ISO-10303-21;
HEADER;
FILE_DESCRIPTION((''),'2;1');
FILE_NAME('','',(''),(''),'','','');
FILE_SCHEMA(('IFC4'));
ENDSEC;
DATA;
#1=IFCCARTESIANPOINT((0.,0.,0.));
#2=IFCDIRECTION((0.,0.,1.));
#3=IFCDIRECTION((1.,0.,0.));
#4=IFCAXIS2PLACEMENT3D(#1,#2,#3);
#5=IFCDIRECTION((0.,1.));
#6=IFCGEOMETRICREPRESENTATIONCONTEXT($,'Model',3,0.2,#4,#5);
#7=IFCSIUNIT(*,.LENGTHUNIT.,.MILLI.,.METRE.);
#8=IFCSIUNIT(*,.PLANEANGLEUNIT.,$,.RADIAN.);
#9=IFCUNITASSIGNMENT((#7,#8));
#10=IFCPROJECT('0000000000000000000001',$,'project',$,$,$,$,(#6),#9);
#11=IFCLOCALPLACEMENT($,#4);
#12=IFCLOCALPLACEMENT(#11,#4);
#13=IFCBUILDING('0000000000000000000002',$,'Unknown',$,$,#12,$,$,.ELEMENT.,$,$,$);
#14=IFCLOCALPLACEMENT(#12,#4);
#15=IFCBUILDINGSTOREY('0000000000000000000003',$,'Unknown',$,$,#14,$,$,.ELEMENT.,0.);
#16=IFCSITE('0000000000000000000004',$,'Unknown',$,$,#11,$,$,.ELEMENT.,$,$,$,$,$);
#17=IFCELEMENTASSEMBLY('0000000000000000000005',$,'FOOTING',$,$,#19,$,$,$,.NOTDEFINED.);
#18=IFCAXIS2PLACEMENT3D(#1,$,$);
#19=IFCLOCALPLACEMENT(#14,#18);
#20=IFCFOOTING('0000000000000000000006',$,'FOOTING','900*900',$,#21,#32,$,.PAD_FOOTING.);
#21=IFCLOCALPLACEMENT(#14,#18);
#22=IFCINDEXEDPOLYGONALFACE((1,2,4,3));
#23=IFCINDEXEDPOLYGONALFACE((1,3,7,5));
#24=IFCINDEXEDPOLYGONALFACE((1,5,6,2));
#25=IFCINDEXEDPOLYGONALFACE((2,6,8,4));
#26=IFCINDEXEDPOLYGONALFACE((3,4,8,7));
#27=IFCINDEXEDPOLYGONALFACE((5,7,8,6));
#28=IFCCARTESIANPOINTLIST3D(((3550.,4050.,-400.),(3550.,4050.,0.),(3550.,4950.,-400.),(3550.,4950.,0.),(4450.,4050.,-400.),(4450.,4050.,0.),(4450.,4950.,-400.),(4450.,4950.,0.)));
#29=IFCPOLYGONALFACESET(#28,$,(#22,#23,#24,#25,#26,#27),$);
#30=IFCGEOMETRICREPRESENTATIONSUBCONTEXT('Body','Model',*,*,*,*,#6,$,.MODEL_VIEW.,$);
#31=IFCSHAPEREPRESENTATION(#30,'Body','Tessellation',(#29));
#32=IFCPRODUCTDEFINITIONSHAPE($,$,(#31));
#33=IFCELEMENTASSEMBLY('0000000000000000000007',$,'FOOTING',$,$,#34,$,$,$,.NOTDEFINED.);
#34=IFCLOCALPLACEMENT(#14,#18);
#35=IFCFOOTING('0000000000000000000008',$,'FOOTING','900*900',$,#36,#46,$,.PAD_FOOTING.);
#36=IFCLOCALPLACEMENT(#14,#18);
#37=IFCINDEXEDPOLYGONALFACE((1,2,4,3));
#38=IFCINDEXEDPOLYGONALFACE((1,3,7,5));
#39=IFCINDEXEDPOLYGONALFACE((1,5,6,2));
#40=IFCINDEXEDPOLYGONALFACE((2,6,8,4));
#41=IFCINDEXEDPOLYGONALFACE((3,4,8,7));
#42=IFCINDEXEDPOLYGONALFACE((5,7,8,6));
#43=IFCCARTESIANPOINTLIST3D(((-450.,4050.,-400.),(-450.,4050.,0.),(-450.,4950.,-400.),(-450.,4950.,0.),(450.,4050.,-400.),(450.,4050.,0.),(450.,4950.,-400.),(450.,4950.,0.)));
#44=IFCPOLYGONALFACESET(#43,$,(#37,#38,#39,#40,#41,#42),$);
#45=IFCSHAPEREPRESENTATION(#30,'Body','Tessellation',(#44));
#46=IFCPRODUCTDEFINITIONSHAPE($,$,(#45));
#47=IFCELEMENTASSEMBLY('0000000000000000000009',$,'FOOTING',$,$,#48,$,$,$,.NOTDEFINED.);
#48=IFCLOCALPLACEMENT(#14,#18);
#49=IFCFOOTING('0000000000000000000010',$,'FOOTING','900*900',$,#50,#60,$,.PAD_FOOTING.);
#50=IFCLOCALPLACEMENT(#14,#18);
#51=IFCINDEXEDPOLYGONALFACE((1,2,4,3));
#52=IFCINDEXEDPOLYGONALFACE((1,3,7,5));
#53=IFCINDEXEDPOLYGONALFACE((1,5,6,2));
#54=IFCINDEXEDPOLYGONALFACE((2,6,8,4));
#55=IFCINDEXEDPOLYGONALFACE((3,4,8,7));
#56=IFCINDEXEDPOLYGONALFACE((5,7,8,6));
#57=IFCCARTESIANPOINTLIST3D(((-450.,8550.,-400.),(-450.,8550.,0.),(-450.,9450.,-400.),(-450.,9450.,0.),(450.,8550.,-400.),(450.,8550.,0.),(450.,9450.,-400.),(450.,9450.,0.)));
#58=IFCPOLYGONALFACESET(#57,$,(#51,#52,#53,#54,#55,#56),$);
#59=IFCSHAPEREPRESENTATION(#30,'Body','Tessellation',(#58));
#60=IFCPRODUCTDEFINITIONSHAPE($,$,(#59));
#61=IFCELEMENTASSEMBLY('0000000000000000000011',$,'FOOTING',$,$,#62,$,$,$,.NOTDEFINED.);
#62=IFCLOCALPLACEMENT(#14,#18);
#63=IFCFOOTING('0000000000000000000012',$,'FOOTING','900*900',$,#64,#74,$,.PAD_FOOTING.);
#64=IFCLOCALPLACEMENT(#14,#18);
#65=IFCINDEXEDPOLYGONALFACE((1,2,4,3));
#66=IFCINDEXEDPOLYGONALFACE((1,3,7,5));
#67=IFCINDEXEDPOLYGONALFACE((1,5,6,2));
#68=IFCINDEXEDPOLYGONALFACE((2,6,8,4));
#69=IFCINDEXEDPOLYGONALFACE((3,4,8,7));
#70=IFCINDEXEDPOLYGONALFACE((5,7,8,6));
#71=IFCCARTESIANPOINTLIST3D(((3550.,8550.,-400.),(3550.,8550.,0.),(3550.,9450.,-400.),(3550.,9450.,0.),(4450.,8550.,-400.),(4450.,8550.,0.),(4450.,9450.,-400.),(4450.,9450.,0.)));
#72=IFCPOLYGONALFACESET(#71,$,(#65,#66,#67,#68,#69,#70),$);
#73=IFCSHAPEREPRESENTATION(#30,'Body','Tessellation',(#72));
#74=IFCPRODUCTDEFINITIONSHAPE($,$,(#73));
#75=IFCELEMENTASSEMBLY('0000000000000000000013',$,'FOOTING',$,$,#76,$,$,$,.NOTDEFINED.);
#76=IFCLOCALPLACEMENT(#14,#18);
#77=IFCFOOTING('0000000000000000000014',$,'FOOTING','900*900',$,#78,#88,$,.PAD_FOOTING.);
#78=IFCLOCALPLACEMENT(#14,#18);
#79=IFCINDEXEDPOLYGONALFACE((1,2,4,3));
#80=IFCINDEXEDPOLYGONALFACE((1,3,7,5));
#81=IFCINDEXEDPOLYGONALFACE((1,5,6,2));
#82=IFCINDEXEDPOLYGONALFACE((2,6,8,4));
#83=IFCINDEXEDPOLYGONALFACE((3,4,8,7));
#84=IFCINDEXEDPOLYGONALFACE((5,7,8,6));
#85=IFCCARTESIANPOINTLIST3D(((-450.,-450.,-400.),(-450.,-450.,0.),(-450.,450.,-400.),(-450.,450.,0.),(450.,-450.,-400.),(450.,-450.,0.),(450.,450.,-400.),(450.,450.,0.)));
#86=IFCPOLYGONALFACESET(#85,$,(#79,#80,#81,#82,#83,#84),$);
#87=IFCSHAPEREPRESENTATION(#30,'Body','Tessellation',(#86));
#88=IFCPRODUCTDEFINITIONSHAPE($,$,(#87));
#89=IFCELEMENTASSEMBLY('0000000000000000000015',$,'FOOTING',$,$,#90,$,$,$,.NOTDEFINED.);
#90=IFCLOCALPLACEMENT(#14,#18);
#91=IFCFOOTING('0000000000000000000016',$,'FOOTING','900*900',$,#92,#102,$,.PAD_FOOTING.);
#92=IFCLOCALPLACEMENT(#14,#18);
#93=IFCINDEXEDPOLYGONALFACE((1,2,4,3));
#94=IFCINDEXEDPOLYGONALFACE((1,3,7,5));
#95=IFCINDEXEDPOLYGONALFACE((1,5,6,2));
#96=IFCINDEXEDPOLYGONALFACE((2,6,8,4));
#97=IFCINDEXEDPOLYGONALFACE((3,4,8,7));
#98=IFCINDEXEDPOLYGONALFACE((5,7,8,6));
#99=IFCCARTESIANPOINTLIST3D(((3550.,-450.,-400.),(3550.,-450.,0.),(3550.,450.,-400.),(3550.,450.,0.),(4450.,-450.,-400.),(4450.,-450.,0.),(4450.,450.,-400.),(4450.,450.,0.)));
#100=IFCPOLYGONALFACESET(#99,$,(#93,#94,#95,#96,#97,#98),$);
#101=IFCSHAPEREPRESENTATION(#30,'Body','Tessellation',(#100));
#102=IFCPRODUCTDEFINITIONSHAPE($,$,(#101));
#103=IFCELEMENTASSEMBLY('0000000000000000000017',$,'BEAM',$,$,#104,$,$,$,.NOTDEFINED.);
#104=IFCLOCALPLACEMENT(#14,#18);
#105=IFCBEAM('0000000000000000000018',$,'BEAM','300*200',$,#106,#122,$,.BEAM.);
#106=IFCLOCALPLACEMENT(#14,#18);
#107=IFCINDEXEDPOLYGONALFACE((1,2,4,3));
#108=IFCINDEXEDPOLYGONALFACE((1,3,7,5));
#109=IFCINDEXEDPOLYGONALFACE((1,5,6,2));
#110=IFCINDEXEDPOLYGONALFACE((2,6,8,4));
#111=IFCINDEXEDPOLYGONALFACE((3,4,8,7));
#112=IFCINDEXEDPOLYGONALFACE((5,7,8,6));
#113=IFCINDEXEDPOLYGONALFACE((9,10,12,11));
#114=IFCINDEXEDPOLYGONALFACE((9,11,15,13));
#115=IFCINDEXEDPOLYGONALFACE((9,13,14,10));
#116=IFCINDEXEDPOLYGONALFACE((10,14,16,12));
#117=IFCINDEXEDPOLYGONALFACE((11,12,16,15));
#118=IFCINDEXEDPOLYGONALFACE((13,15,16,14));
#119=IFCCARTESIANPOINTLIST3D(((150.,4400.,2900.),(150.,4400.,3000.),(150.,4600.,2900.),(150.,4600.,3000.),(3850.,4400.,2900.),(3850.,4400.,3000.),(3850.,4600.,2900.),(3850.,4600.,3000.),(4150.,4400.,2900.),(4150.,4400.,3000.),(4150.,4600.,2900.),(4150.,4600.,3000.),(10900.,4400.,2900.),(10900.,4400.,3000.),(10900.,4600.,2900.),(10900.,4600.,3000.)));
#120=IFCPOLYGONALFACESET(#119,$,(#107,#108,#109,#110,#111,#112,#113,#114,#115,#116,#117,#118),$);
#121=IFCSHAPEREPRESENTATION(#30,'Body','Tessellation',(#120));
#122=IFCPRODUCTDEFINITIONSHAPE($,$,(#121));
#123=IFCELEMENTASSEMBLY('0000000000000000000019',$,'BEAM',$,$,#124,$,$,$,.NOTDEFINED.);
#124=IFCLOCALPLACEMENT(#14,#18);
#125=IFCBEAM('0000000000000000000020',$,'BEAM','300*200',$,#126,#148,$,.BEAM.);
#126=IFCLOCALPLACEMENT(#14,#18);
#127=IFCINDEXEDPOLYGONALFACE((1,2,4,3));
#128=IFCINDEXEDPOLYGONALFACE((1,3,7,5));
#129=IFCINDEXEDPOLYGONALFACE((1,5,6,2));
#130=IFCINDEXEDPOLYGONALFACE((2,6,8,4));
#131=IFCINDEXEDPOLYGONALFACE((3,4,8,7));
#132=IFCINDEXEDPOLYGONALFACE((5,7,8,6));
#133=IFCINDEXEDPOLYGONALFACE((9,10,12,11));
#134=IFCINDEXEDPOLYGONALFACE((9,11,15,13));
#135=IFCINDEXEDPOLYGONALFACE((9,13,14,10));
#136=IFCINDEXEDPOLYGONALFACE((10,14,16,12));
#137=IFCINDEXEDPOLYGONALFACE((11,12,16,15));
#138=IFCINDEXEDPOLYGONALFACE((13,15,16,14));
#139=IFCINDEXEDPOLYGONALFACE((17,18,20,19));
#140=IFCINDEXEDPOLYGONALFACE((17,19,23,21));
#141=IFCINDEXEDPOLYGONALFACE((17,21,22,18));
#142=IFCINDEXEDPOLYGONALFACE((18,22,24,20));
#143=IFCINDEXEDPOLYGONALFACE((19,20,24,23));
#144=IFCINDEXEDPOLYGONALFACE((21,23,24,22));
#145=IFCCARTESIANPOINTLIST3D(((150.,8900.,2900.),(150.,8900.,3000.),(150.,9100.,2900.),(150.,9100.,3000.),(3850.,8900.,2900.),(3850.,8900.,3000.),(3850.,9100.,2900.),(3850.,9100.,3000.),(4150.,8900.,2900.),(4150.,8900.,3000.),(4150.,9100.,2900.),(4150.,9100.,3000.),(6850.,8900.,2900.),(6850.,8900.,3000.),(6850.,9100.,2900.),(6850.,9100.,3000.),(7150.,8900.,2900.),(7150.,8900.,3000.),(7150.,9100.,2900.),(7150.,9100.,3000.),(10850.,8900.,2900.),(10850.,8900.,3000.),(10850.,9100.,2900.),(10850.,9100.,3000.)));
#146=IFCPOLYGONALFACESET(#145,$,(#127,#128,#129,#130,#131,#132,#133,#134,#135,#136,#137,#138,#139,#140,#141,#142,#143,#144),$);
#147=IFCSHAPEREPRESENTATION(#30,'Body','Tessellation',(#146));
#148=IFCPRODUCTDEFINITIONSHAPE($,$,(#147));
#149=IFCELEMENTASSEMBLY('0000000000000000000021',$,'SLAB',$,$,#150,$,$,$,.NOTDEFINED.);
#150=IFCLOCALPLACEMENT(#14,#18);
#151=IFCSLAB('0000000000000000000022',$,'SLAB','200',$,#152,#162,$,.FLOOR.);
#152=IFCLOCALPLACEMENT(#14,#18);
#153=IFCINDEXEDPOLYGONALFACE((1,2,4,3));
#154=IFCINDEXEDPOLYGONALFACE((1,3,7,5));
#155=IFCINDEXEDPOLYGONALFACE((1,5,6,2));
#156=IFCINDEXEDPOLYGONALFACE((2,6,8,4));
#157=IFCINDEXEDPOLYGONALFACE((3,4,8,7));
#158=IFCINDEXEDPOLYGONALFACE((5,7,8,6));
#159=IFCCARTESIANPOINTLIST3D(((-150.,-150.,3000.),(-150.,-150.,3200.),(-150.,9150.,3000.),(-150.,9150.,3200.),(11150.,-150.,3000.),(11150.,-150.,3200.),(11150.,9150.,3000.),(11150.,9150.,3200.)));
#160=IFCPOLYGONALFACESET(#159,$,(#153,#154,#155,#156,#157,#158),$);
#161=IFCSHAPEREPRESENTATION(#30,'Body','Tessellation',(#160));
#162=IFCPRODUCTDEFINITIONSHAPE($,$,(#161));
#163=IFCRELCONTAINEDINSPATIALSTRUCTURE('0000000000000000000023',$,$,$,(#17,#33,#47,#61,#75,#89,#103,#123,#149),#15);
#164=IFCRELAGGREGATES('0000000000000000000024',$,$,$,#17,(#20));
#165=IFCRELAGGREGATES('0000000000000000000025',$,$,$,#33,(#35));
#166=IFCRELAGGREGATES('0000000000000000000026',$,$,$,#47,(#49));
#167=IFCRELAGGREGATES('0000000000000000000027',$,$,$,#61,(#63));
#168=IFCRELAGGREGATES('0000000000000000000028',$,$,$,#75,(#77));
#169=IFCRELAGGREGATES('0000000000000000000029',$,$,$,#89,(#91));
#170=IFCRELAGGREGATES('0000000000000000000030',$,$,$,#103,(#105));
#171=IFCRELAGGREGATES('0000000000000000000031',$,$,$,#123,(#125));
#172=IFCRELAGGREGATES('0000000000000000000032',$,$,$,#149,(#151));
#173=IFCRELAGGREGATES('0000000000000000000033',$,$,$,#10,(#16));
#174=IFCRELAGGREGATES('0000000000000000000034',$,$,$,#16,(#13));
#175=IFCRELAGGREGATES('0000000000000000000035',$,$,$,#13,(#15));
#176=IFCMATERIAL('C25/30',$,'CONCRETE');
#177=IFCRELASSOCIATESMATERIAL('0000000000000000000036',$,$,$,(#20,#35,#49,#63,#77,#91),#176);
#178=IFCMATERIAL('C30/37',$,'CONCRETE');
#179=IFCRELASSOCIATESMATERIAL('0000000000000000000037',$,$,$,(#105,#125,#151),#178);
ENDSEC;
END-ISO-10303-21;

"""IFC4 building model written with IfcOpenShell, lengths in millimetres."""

from ifc_helpers import new_model, si_unit, direction, frame, origin_with_axes, place, context, subcontext, project, spatial, line, indexed_curve, outline, extrude, material, element, aggregate, save


model = new_model("IFC4")

# Units and contexts
model_context = context("Model", 3, precision=0.2, world=origin_with_axes(), true_north=direction((0.0, 1.0)))
body_context = subcontext(model_context, "Body", "Model", "MODEL_VIEW")
ifc_project = project(units=[si_unit("LENGTHUNIT", "METRE", prefix="MILLI"), si_unit("PLANEANGLEUNIT", "RADIAN")], contexts=[model_context])

# Site, building, storey
site_placement = place(None, origin_with_axes())
site = spatial("IfcSite", under=ifc_project, at=site_placement, Name="Unknown", CompositionType="ELEMENT")
building_placement = place(site_placement, origin_with_axes())
building = spatial("IfcBuilding", under=site, at=building_placement, Name="Unknown", CompositionType="ELEMENT")
storey_placement = place(building_placement, origin_with_axes())
storey = spatial("IfcBuildingStorey", under=building, at=storey_placement, Name="Unknown", CompositionType="ELEMENT", Elevation=0.0)

# Element assemblies, footings
assembly_1_placement = place(storey_placement, frame((4000.0, 4500.0, -400.0), z_axis=(-1.0, 0.0, 0.0), x_axis=(0.0, 0.0, 1.0)))
assembly_1 = element("IfcElementAssembly", 1, at=assembly_1_placement, inside=storey, Name="FOOTING", PredefinedType="NOTDEFINED")
ifc_material_1 = material(Name="C25/30", Category="CONCRETE")
footing_1_placement = place(assembly_1_placement, origin_with_axes())
footing_1 = element("IfcFooting", 2, at=footing_1_placement, material=ifc_material_1, Name="FOOTING", Description="900*900", PredefinedType="PAD_FOOTING", context=body_context, shape_type="SolidModel", body=[
    extrude(outline(indexed_curve([(-450.0, -450.0), (450.0, -450.0), (450.0, 450.0), (-450.0, 450.0)], segments=[line(1, 2, 3, 4, 1)])), frame((0.0, 0.0, 0.0), z_axis=(-1.0, 0.0, 0.0), x_axis=(0.0, 0.0, 1.0)), (0.0, 0.0, -1.0), 400.0),
])
aggregate(assembly_1, [footing_1])
assembly_2_placement = place(storey_placement, frame((0.0, 4500.0, -400.0), z_axis=(-1.0, 0.0, 0.0), x_axis=(0.0, 0.0, 1.0)))
assembly_2 = element("IfcElementAssembly", 3, at=assembly_2_placement, inside=storey, Name="FOOTING", PredefinedType="NOTDEFINED")
footing_2_placement = place(assembly_2_placement, origin_with_axes())
footing_2 = element("IfcFooting", 4, at=footing_2_placement, material=ifc_material_1, Name="FOOTING", Description="900*900", PredefinedType="PAD_FOOTING", context=body_context, shape_type="SolidModel", body=[
    extrude(outline(indexed_curve([(-450.0, -450.0), (450.0, -450.0), (450.0, 450.0), (-450.0, 450.0)], segments=[line(1, 2, 3, 4, 1)])), frame((0.0, 0.0, 0.0), z_axis=(-1.0, 0.0, 0.0), x_axis=(0.0, 0.0, 1.0)), (0.0, 0.0, -1.0), 400.0),
])
aggregate(assembly_2, [footing_2])
assembly_3_placement = place(storey_placement, frame((0.0, 9000.0, -400.0), z_axis=(-1.0, 0.0, 0.0), x_axis=(0.0, 0.0, 1.0)))
assembly_3 = element("IfcElementAssembly", 5, at=assembly_3_placement, inside=storey, Name="FOOTING", PredefinedType="NOTDEFINED")
footing_3_placement = place(assembly_3_placement, origin_with_axes())
footing_3 = element("IfcFooting", 6, at=footing_3_placement, material=ifc_material_1, Name="FOOTING", Description="900*900", PredefinedType="PAD_FOOTING", context=body_context, shape_type="SolidModel", body=[
    extrude(outline(indexed_curve([(-450.0, -450.0), (450.0, -450.0), (450.0, 450.0), (-450.0, 450.0)], segments=[line(1, 2, 3, 4, 1)])), frame((0.0, 0.0, 0.0), z_axis=(-1.0, 0.0, 0.0), x_axis=(0.0, 0.0, 1.0)), (0.0, 0.0, -1.0), 400.0),
])
aggregate(assembly_3, [footing_3])
assembly_4_placement = place(storey_placement, frame((4000.0, 9000.0, -400.0), z_axis=(-1.0, 0.0, 0.0), x_axis=(0.0, 0.0, 1.0)))
assembly_4 = element("IfcElementAssembly", 7, at=assembly_4_placement, inside=storey, Name="FOOTING", PredefinedType="NOTDEFINED")
footing_4_placement = place(assembly_4_placement, origin_with_axes())
footing_4 = element("IfcFooting", 8, at=footing_4_placement, material=ifc_material_1, Name="FOOTING", Description="900*900", PredefinedType="PAD_FOOTING", context=body_context, shape_type="SolidModel", body=[
    extrude(outline(indexed_curve([(-450.0, -450.0), (450.0, -450.0), (450.0, 450.0), (-450.0, 450.0)], segments=[line(1, 2, 3, 4, 1)])), frame((0.0, 0.0, 0.0), z_axis=(-1.0, 0.0, 0.0), x_axis=(0.0, 0.0, 1.0)), (0.0, 0.0, -1.0), 400.0),
])
aggregate(assembly_4, [footing_4])
assembly_5_placement = place(storey_placement, frame((0.0, 0.0, -400.0), z_axis=(-1.0, 0.0, 0.0), x_axis=(0.0, 0.0, 1.0)))
assembly_5 = element("IfcElementAssembly", 9, at=assembly_5_placement, inside=storey, Name="FOOTING", PredefinedType="NOTDEFINED")
footing_5_placement = place(assembly_5_placement, origin_with_axes())
footing_5 = element("IfcFooting", 10, at=footing_5_placement, material=ifc_material_1, Name="FOOTING", Description="900*900", PredefinedType="PAD_FOOTING", context=body_context, shape_type="SolidModel", body=[
    extrude(outline(indexed_curve([(-450.0, -450.0), (450.0, -450.0), (450.0, 450.0), (-450.0, 450.0)], segments=[line(1, 2, 3, 4, 1)])), frame((0.0, 0.0, 0.0), z_axis=(-1.0, 0.0, 0.0), x_axis=(0.0, 0.0, 1.0)), (0.0, 0.0, -1.0), 400.0),
])
aggregate(assembly_5, [footing_5])
assembly_6_placement = place(storey_placement, frame((4000.0, 0.0, -400.0), z_axis=(-1.0, 0.0, 0.0), x_axis=(0.0, 0.0, 1.0)))
assembly_6 = element("IfcElementAssembly", 11, at=assembly_6_placement, inside=storey, Name="FOOTING", PredefinedType="NOTDEFINED")
footing_6_placement = place(assembly_6_placement, origin_with_axes())
footing_6 = element("IfcFooting", 12, at=footing_6_placement, material=ifc_material_1, Name="FOOTING", Description="900*900", PredefinedType="PAD_FOOTING", context=body_context, shape_type="SolidModel", body=[
    extrude(outline(indexed_curve([(-450.0, -450.0), (450.0, -450.0), (450.0, 450.0), (-450.0, 450.0)], segments=[line(1, 2, 3, 4, 1)])), frame((0.0, 0.0, 0.0), z_axis=(-1.0, 0.0, 0.0), x_axis=(0.0, 0.0, 1.0)), (0.0, 0.0, -1.0), 400.0),
])
aggregate(assembly_6, [footing_6])

# Shared definitions
ifc_material_2 = material(Name="C30/37", Category="CONCRETE")

# Element assembly, beam, voiding features
assembly_7_placement = place(storey_placement, frame((150.0, 4500.0, 3050.0), z_axis=(0.0, -1.0, 0.0), x_axis=(1.0, 0.0, 0.0)))
assembly_7 = element("IfcElementAssembly", 13, at=assembly_7_placement, inside=storey, Name="BEAM", PredefinedType="NOTDEFINED")
beam_1_placement = place(assembly_7_placement, origin_with_axes())
beam_1 = element("IfcBeam", 14, at=beam_1_placement, material=ifc_material_2, Name="BEAM", Description="300*200", PredefinedType="BEAM", context=body_context, shape_type="SolidModel", body=[
    extrude(outline(indexed_curve([(-100.0, -150.0), (100.0, -150.0), (100.0, 150.0), (-100.0, 150.0)], segments=[line(1, 2, 3, 4, 1)])), frame((0.0, 0.0, 0.0), z_axis=(-1.0, 0.0, 0.0), x_axis=(0.0, 0.0, 1.0)), (0.0, 0.0, -1.0), 10750.0),
])
voiding_feature_1_placement = place(beam_1_placement, frame((3850.0, -3050.0, 0.0), z_axis=(-1.0, 0.0, 0.0), x_axis=(0.0, 1.0, 0.0)))
element("IfcVoidingFeature", 15, at=voiding_feature_1_placement, cuts=beam_1, Name="COLUMN", PredefinedType="HOLE", context=body_context, shape_type="SolidModel", body=[
    extrude(outline(indexed_curve([(-150.0, -150.0), (150.0, -150.0), (150.0, 150.0), (-150.0, 150.0)], segments=[line(1, 2, 3, 4, 1)])), frame((0.0, 0.0, 0.0), z_axis=(-1.0, 0.0, 0.0), x_axis=(0.0, 0.0, 1.0)), (0.0, 0.0, -1.0), 3200.0),
])
voiding_feature_2_placement = place(beam_1_placement, frame((-300.0, 50.0, 4650.0), z_axis=(0.0, 1.0, 0.0), x_axis=(1.0, 0.0, 0.0)))
element("IfcVoidingFeature", 16, at=voiding_feature_2_placement, cuts=beam_1, Name="SLAB", PredefinedType="HOLE", context=body_context, shape_type="SolidModel", body=[
    extrude(outline(indexed_curve([(0.0, 0.0), (11300.0, 0.0), (11300.0, 9300.0), (0.0, 9300.0)], segments=[line(1, 2, 3, 4, 1)])), frame((0.0, 0.0, 100.0), z_axis=(0.0, 0.0, 1.0), x_axis=(1.0, 0.0, 0.0)), (0.0, 0.0, -1.0), 200.0),
])
voiding_feature_3_placement = place(beam_1_placement, frame((3850.0, 0.0, -4350.0), z_axis=(-1.0, 0.0, 0.0), x_axis=(0.0, 0.0, 1.0)))
element("IfcVoidingFeature", 17, at=voiding_feature_3_placement, cuts=beam_1, Name="BEAM", PredefinedType="HOLE", context=body_context, shape_type="SolidModel", body=[
    extrude(outline(indexed_curve([(-100.0, -150.0), (100.0, -150.0), (100.0, 150.0), (-100.0, 150.0)], segments=[line(1, 2, 3, 4, 1)])), frame((0.0, 0.0, 0.0), z_axis=(-1.0, 0.0, 0.0), x_axis=(0.0, 0.0, 1.0)), (0.0, 0.0, -1.0), 8700.0),
])
aggregate(assembly_7, [beam_1])

# Element assembly, beam, voiding features
assembly_8_placement = place(storey_placement, frame((150.0, 9000.0, 3050.0), z_axis=(0.0, -1.0, 0.0), x_axis=(1.0, 0.0, 0.0)))
assembly_8 = element("IfcElementAssembly", 18, at=assembly_8_placement, inside=storey, Name="BEAM", PredefinedType="NOTDEFINED")
beam_2_placement = place(assembly_8_placement, origin_with_axes())
beam_2 = element("IfcBeam", 19, at=beam_2_placement, material=ifc_material_2, Name="BEAM", Description="300*200", PredefinedType="BEAM", context=body_context, shape_type="SolidModel", body=[
    extrude(outline(indexed_curve([(-100.0, -150.0), (100.0, -150.0), (100.0, 150.0), (-100.0, 150.0)], segments=[line(1, 2, 3, 4, 1)])), frame((0.0, 0.0, 0.0), z_axis=(-1.0, 0.0, 0.0), x_axis=(0.0, 0.0, 1.0)), (0.0, 0.0, -1.0), 10700.0),
])
voiding_feature_4_placement = place(beam_2_placement, frame((3850.0, -3050.0, 0.0), z_axis=(-1.0, 0.0, 0.0), x_axis=(0.0, 1.0, 0.0)))
element("IfcVoidingFeature", 20, at=voiding_feature_4_placement, cuts=beam_2, Name="COLUMN", PredefinedType="HOLE", context=body_context, shape_type="SolidModel", body=[
    extrude(outline(indexed_curve([(-150.0, -150.0), (150.0, -150.0), (150.0, 150.0), (-150.0, 150.0)], segments=[line(1, 2, 3, 4, 1)])), frame((0.0, 0.0, 0.0), z_axis=(-1.0, 0.0, 0.0), x_axis=(0.0, 0.0, 1.0)), (0.0, 0.0, -1.0), 3200.0),
])
voiding_feature_5_placement = place(beam_2_placement, frame((6850.0, -3050.0, 0.0), z_axis=(-1.0, 0.0, 0.0), x_axis=(0.0, 1.0, 0.0)))
element("IfcVoidingFeature", 21, at=voiding_feature_5_placement, cuts=beam_2, Name="COLUMN", PredefinedType="HOLE", context=body_context, shape_type="SolidModel", body=[
    extrude(outline(indexed_curve([(-150.0, -150.0), (150.0, -150.0), (150.0, 150.0), (-150.0, 150.0)], segments=[line(1, 2, 3, 4, 1)])), frame((0.0, 0.0, 0.0), z_axis=(-1.0, 0.0, 0.0), x_axis=(0.0, 0.0, 1.0)), (0.0, 0.0, -1.0), 3200.0),
])
voiding_feature_6_placement = place(beam_2_placement, frame((-300.0, 50.0, 9150.0), z_axis=(0.0, 1.0, 0.0), x_axis=(1.0, 0.0, 0.0)))
element("IfcVoidingFeature", 22, at=voiding_feature_6_placement, cuts=beam_2, Name="SLAB", PredefinedType="HOLE", context=body_context, shape_type="SolidModel", body=[
    extrude(outline(indexed_curve([(0.0, 0.0), (11300.0, 0.0), (11300.0, 9300.0), (0.0, 9300.0)], segments=[line(1, 2, 3, 4, 1)])), frame((0.0, 0.0, 100.0), z_axis=(0.0, 0.0, 1.0), x_axis=(1.0, 0.0, 0.0)), (0.0, 0.0, -1.0), 200.0),
])
aggregate(assembly_8, [beam_2])

# Element assembly, slab
assembly_9_placement = place(storey_placement, frame((-150.0, -150.0, 3100.0), z_axis=(0.0, 0.0, 1.0), x_axis=(1.0, 0.0, 0.0)))
assembly_9 = element("IfcElementAssembly", 23, at=assembly_9_placement, inside=storey, Name="SLAB", PredefinedType="NOTDEFINED")
slab_placement = place(assembly_9_placement, origin_with_axes())
slab = element("IfcSlab", 24, at=slab_placement, material=ifc_material_2, Name="SLAB", Description="200", PredefinedType="FLOOR", context=body_context, shape_type="SolidModel", body=[
    extrude(outline(indexed_curve([(0.0, 0.0), (11300.0, 0.0), (11300.0, 9300.0), (0.0, 9300.0)], segments=[line(1, 2, 3, 4, 1)])), frame((0.0, 0.0, 100.0), z_axis=(0.0, 0.0, 1.0), x_axis=(1.0, 0.0, 0.0)), (0.0, 0.0, -1.0), 200.0),
])
aggregate(assembly_9, [slab])

save(model, "model.ifc")
